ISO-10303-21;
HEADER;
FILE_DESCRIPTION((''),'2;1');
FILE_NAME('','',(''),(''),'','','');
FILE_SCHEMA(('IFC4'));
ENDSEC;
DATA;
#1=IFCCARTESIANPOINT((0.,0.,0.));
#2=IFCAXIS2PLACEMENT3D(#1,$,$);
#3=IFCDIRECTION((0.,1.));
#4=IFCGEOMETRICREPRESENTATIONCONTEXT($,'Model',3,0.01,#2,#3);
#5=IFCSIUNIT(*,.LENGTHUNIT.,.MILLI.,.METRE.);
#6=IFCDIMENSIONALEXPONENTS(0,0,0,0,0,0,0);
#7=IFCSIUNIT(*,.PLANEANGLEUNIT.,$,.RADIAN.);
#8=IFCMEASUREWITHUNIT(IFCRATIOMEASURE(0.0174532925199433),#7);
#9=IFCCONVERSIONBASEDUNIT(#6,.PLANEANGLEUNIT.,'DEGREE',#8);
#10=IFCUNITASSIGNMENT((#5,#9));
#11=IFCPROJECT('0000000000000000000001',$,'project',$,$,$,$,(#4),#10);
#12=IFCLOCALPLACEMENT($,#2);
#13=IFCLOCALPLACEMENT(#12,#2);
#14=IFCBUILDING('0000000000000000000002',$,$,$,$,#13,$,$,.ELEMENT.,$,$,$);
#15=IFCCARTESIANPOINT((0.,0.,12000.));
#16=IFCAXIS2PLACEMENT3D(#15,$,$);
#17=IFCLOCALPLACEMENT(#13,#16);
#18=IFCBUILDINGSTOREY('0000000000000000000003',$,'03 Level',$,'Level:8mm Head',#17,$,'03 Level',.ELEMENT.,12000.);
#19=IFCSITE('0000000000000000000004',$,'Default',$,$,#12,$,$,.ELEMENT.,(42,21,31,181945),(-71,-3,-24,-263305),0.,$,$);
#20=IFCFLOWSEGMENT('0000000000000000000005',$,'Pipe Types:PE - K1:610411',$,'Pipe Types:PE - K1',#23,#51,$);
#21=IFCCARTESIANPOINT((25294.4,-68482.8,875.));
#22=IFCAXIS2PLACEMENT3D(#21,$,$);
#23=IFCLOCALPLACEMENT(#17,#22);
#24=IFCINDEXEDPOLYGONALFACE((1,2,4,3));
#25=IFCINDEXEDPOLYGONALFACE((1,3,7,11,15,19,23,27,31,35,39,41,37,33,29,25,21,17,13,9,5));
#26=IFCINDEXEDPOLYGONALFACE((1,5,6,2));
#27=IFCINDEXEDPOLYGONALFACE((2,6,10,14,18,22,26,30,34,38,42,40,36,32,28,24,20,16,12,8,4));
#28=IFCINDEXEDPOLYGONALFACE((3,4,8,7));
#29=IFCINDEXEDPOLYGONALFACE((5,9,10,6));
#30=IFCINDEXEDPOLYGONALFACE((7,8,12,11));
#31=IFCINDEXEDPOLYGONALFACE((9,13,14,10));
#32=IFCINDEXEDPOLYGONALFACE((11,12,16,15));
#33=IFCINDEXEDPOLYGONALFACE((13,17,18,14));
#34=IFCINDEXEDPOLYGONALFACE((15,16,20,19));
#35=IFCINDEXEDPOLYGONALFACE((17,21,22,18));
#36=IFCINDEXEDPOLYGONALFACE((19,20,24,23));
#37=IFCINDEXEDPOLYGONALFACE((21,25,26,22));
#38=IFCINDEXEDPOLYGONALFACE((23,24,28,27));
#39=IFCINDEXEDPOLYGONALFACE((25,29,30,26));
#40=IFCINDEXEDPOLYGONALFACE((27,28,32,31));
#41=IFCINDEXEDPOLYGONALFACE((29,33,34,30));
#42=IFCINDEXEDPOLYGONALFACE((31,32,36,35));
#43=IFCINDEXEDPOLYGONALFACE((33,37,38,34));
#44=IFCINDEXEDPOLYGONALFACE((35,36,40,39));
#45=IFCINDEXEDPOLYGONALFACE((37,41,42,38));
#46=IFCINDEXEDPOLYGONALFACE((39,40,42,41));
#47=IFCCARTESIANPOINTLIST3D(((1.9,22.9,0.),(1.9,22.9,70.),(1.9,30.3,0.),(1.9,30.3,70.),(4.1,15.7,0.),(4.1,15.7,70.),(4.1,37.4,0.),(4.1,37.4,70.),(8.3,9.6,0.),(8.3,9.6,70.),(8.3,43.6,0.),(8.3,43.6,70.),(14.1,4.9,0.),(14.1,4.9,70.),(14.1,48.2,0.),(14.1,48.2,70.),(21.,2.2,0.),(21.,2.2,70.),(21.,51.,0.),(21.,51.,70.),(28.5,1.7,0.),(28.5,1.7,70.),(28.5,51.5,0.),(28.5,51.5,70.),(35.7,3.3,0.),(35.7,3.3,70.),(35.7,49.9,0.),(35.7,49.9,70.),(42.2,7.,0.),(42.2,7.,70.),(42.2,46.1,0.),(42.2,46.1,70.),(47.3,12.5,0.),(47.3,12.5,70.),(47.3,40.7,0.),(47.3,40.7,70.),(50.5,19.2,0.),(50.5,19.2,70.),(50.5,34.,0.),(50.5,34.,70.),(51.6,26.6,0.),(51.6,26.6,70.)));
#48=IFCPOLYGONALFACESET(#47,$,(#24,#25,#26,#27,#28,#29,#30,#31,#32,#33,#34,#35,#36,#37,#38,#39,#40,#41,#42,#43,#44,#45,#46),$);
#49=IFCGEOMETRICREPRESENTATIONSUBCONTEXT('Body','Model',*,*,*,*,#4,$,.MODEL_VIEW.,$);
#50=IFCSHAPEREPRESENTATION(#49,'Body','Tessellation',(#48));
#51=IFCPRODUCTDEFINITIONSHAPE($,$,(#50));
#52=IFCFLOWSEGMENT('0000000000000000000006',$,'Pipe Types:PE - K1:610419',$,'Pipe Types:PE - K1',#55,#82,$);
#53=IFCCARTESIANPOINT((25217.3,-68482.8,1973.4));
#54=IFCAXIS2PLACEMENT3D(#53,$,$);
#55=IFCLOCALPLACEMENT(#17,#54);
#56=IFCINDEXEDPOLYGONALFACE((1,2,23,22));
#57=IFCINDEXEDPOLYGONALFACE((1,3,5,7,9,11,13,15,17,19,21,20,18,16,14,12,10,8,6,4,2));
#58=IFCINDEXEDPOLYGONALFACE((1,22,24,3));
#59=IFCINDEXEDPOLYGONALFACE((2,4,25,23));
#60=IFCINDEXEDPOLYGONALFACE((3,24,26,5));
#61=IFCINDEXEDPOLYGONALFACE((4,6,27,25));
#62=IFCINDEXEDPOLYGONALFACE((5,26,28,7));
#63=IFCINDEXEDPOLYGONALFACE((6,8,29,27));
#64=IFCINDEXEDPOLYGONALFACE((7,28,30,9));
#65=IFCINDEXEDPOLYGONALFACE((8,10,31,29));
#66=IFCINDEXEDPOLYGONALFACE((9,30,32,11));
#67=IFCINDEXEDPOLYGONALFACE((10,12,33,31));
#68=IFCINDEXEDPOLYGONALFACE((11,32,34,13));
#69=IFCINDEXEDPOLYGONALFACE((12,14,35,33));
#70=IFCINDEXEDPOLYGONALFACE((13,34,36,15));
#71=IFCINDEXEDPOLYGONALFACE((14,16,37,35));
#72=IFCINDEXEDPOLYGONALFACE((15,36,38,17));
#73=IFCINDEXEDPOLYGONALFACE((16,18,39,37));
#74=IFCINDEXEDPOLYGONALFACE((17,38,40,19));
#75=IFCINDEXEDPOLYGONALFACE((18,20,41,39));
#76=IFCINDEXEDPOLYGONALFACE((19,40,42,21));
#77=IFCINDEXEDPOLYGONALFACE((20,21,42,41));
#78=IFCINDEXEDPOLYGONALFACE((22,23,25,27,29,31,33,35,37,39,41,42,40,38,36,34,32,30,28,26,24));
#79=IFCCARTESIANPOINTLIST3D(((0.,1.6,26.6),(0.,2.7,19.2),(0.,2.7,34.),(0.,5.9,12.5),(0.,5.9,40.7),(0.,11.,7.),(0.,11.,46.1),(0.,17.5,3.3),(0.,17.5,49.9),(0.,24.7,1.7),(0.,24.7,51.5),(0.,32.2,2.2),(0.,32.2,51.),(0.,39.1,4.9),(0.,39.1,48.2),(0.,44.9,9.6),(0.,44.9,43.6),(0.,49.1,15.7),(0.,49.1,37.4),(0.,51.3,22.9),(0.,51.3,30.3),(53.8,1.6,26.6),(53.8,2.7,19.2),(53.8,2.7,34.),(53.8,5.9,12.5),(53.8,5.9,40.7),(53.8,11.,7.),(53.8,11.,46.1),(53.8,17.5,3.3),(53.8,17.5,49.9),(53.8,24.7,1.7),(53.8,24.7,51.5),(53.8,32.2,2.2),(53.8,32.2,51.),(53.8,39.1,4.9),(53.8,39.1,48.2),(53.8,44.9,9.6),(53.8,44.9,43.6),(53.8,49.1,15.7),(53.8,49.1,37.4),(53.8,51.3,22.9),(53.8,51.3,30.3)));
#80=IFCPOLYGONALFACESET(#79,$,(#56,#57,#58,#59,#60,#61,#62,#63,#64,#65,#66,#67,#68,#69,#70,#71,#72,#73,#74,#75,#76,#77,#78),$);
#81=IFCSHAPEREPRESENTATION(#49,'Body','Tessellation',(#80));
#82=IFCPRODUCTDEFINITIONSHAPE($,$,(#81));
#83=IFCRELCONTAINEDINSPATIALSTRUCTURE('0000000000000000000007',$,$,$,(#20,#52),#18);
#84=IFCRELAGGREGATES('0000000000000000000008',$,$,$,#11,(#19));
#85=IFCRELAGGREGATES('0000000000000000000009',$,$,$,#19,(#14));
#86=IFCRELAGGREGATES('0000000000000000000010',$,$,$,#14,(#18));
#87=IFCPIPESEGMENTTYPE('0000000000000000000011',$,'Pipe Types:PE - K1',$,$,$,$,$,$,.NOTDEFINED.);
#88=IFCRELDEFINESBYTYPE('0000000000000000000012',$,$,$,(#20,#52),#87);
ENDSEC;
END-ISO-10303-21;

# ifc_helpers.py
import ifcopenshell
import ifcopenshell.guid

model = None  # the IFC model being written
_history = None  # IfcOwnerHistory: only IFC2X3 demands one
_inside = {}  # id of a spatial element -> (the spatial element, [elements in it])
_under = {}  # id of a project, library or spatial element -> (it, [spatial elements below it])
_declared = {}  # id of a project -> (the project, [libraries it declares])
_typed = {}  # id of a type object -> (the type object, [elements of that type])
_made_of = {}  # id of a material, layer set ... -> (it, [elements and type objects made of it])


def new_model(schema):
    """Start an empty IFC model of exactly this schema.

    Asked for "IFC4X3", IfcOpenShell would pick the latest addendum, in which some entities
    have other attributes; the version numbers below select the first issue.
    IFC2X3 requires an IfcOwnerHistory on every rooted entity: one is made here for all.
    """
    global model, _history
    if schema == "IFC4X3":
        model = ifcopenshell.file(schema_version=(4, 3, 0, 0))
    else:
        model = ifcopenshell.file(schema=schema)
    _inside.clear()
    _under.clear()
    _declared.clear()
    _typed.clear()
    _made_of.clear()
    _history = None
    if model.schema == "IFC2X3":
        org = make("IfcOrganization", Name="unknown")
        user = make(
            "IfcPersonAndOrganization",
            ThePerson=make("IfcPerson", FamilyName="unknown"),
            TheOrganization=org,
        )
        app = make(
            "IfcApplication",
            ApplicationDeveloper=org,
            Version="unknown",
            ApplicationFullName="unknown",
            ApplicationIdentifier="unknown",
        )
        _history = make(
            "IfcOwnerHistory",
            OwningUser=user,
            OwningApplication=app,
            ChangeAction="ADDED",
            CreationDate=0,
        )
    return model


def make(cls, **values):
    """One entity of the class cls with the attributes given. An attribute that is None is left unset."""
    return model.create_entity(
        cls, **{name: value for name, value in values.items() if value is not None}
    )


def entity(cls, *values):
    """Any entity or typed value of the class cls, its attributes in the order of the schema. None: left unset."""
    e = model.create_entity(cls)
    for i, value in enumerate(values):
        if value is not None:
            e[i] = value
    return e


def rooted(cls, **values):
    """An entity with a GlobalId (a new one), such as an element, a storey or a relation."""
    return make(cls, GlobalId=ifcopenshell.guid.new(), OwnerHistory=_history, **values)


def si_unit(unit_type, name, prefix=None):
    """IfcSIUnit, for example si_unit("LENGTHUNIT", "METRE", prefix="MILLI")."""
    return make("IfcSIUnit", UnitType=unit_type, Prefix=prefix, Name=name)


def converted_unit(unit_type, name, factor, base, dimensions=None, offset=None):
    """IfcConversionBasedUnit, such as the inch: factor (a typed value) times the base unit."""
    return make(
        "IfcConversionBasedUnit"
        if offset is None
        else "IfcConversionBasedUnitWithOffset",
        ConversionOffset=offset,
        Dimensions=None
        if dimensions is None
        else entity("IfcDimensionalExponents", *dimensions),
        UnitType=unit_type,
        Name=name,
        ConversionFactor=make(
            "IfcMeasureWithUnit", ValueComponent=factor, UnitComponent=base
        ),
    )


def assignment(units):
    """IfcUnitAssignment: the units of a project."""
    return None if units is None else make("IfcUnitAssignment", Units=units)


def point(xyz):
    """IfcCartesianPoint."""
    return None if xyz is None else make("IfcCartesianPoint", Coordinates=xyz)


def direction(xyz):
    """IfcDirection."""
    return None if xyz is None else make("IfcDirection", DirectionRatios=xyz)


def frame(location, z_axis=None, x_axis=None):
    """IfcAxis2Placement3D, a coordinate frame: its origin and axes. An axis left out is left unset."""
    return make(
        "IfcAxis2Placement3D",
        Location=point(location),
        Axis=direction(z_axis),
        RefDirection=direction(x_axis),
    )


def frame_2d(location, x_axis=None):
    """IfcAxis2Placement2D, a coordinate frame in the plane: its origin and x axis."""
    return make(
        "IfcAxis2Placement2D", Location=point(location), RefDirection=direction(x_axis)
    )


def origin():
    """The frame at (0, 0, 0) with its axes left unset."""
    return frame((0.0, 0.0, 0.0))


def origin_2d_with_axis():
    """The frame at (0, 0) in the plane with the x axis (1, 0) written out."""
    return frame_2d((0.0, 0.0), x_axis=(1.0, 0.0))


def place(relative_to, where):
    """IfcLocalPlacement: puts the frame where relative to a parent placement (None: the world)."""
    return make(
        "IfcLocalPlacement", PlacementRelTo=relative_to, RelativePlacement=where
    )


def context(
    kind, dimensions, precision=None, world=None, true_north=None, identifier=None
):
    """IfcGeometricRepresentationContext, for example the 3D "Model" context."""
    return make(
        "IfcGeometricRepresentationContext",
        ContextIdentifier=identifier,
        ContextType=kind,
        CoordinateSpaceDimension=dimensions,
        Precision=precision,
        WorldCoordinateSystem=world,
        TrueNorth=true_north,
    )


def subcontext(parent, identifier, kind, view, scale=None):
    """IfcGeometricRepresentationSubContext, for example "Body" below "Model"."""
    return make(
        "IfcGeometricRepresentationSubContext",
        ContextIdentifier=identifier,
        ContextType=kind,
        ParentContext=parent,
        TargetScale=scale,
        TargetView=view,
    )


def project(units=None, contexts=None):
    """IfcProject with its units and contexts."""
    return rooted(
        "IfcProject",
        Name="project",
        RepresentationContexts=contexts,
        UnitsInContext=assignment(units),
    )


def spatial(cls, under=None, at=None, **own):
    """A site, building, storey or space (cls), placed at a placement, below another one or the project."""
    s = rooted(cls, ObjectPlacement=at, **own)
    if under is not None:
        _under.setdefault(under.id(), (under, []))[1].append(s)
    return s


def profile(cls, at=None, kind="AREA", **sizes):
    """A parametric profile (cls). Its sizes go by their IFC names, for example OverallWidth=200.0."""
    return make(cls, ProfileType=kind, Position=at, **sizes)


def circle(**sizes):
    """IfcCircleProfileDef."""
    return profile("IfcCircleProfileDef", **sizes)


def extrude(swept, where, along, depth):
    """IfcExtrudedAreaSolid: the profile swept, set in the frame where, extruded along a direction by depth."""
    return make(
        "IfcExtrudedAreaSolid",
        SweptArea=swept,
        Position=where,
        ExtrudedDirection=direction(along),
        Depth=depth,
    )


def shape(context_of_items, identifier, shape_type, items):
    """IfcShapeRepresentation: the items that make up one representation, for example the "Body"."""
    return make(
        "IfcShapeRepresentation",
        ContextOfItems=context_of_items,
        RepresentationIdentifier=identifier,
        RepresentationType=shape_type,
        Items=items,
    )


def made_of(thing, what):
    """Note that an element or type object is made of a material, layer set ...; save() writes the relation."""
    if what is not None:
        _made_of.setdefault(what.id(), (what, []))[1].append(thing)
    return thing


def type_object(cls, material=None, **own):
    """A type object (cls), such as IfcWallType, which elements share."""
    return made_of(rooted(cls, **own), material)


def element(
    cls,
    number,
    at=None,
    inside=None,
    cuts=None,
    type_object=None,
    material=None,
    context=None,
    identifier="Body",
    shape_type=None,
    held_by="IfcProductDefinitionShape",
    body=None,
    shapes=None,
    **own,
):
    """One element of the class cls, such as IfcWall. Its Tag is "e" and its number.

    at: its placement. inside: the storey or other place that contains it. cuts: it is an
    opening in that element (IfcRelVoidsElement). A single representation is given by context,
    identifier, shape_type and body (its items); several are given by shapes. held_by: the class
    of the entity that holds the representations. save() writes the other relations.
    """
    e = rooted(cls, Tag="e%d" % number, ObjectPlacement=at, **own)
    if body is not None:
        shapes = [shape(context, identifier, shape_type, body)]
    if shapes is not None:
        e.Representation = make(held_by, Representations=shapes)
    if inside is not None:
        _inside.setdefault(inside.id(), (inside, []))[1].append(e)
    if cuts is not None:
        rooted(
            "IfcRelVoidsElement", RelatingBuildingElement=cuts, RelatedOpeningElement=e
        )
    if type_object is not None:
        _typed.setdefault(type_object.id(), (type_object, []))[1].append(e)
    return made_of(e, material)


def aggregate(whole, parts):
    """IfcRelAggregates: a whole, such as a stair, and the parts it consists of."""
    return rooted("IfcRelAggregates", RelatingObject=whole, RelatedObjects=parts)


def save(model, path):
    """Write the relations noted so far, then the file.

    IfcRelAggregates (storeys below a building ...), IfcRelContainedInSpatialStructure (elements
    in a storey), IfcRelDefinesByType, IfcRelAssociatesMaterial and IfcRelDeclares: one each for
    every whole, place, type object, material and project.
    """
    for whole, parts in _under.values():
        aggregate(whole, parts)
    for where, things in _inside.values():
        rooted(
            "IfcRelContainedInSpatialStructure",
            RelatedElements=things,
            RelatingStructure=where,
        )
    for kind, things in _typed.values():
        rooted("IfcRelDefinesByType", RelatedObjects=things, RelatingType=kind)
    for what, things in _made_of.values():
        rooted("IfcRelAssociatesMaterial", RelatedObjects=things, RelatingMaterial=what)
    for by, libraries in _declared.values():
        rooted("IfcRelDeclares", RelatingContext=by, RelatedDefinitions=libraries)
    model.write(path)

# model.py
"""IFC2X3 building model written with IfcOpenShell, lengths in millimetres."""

from ifc_helpers import new_model, entity, si_unit, converted_unit, direction, frame, frame_2d, origin, origin_2d_with_axis, place, context, subcontext, project, spatial, circle, extrude, type_object, element, save


model = new_model("IFC2X3")

# Units and contexts
model_context = context("Model", 3, precision=0.01, world=origin(), true_north=direction((0.0, 1.0)))
body_context = subcontext(model_context, "Body", "Model", "MODEL_VIEW")
ifc_project = project(units=[si_unit("LENGTHUNIT", "METRE", prefix="MILLI"), converted_unit("PLANEANGLEUNIT", "DEGREE", entity("IfcRatioMeasure", 0.0174532925199433), si_unit("PLANEANGLEUNIT", "RADIAN"), dimensions=[0, 0, 0, 0, 0, 0, 0])], contexts=[model_context])

# Site, building, storey
site_placement = place(None, origin())
site = spatial("IfcSite", under=ifc_project, at=site_placement, Name="Default", CompositionType="ELEMENT", RefLatitude=(42, 21, 31, 181945), RefLongitude=(-71, -3, -24, -263305), RefElevation=0.0)
building_placement = place(site_placement, origin())
building = spatial("IfcBuilding", under=site, at=building_placement, CompositionType="ELEMENT")
storey_placement = place(building_placement, frame((0.0, 0.0, 12000.0)))
storey = spatial("IfcBuildingStorey", under=building, at=storey_placement, Name="03 Level", ObjectType="Level:8mm Head", LongName="03 Level", CompositionType="ELEMENT", Elevation=12000.0)

# Flow segments
pipe_segment_type_1 = type_object("IfcPipeSegmentType", Name="Pipe Types:PE - K1", PredefinedType="NOTDEFINED")
flow_segment_1_placement = place(storey_placement, frame((25294.4, -68482.8, 875.0)))
element("IfcFlowSegment", 1, at=flow_segment_1_placement, inside=storey, type_object=pipe_segment_type_1, Name="Pipe Types:PE - K1:610411", ObjectType="Pipe Types:PE - K1", context=body_context, shape_type="SweptSolid", body=[
    extrude(circle(Radius=25.0, at=origin_2d_with_axis()), frame((26.6, 26.6, 0.0)), (0.0, 0.0, 1.0), 70.0),
])
flow_segment_2_placement = place(storey_placement, frame((25217.3, -68482.8, 1973.4)))
element("IfcFlowSegment", 2, at=flow_segment_2_placement, inside=storey, type_object=pipe_segment_type_1, Name="Pipe Types:PE - K1:610419", ObjectType="Pipe Types:PE - K1", context=body_context, shape_type="SweptSolid", body=[
    extrude(circle(Radius=25.0, at=frame_2d((0.0, 0.0), x_axis=(1.0, 0.0))), frame((0.0, 26.6, 26.6), z_axis=(1.0, 0.0, 0.0), x_axis=(0.0, -1.0, 0.0)), (0.0, 0.0, 1.0), 53.8),
])

save(model, "model.ifc")
